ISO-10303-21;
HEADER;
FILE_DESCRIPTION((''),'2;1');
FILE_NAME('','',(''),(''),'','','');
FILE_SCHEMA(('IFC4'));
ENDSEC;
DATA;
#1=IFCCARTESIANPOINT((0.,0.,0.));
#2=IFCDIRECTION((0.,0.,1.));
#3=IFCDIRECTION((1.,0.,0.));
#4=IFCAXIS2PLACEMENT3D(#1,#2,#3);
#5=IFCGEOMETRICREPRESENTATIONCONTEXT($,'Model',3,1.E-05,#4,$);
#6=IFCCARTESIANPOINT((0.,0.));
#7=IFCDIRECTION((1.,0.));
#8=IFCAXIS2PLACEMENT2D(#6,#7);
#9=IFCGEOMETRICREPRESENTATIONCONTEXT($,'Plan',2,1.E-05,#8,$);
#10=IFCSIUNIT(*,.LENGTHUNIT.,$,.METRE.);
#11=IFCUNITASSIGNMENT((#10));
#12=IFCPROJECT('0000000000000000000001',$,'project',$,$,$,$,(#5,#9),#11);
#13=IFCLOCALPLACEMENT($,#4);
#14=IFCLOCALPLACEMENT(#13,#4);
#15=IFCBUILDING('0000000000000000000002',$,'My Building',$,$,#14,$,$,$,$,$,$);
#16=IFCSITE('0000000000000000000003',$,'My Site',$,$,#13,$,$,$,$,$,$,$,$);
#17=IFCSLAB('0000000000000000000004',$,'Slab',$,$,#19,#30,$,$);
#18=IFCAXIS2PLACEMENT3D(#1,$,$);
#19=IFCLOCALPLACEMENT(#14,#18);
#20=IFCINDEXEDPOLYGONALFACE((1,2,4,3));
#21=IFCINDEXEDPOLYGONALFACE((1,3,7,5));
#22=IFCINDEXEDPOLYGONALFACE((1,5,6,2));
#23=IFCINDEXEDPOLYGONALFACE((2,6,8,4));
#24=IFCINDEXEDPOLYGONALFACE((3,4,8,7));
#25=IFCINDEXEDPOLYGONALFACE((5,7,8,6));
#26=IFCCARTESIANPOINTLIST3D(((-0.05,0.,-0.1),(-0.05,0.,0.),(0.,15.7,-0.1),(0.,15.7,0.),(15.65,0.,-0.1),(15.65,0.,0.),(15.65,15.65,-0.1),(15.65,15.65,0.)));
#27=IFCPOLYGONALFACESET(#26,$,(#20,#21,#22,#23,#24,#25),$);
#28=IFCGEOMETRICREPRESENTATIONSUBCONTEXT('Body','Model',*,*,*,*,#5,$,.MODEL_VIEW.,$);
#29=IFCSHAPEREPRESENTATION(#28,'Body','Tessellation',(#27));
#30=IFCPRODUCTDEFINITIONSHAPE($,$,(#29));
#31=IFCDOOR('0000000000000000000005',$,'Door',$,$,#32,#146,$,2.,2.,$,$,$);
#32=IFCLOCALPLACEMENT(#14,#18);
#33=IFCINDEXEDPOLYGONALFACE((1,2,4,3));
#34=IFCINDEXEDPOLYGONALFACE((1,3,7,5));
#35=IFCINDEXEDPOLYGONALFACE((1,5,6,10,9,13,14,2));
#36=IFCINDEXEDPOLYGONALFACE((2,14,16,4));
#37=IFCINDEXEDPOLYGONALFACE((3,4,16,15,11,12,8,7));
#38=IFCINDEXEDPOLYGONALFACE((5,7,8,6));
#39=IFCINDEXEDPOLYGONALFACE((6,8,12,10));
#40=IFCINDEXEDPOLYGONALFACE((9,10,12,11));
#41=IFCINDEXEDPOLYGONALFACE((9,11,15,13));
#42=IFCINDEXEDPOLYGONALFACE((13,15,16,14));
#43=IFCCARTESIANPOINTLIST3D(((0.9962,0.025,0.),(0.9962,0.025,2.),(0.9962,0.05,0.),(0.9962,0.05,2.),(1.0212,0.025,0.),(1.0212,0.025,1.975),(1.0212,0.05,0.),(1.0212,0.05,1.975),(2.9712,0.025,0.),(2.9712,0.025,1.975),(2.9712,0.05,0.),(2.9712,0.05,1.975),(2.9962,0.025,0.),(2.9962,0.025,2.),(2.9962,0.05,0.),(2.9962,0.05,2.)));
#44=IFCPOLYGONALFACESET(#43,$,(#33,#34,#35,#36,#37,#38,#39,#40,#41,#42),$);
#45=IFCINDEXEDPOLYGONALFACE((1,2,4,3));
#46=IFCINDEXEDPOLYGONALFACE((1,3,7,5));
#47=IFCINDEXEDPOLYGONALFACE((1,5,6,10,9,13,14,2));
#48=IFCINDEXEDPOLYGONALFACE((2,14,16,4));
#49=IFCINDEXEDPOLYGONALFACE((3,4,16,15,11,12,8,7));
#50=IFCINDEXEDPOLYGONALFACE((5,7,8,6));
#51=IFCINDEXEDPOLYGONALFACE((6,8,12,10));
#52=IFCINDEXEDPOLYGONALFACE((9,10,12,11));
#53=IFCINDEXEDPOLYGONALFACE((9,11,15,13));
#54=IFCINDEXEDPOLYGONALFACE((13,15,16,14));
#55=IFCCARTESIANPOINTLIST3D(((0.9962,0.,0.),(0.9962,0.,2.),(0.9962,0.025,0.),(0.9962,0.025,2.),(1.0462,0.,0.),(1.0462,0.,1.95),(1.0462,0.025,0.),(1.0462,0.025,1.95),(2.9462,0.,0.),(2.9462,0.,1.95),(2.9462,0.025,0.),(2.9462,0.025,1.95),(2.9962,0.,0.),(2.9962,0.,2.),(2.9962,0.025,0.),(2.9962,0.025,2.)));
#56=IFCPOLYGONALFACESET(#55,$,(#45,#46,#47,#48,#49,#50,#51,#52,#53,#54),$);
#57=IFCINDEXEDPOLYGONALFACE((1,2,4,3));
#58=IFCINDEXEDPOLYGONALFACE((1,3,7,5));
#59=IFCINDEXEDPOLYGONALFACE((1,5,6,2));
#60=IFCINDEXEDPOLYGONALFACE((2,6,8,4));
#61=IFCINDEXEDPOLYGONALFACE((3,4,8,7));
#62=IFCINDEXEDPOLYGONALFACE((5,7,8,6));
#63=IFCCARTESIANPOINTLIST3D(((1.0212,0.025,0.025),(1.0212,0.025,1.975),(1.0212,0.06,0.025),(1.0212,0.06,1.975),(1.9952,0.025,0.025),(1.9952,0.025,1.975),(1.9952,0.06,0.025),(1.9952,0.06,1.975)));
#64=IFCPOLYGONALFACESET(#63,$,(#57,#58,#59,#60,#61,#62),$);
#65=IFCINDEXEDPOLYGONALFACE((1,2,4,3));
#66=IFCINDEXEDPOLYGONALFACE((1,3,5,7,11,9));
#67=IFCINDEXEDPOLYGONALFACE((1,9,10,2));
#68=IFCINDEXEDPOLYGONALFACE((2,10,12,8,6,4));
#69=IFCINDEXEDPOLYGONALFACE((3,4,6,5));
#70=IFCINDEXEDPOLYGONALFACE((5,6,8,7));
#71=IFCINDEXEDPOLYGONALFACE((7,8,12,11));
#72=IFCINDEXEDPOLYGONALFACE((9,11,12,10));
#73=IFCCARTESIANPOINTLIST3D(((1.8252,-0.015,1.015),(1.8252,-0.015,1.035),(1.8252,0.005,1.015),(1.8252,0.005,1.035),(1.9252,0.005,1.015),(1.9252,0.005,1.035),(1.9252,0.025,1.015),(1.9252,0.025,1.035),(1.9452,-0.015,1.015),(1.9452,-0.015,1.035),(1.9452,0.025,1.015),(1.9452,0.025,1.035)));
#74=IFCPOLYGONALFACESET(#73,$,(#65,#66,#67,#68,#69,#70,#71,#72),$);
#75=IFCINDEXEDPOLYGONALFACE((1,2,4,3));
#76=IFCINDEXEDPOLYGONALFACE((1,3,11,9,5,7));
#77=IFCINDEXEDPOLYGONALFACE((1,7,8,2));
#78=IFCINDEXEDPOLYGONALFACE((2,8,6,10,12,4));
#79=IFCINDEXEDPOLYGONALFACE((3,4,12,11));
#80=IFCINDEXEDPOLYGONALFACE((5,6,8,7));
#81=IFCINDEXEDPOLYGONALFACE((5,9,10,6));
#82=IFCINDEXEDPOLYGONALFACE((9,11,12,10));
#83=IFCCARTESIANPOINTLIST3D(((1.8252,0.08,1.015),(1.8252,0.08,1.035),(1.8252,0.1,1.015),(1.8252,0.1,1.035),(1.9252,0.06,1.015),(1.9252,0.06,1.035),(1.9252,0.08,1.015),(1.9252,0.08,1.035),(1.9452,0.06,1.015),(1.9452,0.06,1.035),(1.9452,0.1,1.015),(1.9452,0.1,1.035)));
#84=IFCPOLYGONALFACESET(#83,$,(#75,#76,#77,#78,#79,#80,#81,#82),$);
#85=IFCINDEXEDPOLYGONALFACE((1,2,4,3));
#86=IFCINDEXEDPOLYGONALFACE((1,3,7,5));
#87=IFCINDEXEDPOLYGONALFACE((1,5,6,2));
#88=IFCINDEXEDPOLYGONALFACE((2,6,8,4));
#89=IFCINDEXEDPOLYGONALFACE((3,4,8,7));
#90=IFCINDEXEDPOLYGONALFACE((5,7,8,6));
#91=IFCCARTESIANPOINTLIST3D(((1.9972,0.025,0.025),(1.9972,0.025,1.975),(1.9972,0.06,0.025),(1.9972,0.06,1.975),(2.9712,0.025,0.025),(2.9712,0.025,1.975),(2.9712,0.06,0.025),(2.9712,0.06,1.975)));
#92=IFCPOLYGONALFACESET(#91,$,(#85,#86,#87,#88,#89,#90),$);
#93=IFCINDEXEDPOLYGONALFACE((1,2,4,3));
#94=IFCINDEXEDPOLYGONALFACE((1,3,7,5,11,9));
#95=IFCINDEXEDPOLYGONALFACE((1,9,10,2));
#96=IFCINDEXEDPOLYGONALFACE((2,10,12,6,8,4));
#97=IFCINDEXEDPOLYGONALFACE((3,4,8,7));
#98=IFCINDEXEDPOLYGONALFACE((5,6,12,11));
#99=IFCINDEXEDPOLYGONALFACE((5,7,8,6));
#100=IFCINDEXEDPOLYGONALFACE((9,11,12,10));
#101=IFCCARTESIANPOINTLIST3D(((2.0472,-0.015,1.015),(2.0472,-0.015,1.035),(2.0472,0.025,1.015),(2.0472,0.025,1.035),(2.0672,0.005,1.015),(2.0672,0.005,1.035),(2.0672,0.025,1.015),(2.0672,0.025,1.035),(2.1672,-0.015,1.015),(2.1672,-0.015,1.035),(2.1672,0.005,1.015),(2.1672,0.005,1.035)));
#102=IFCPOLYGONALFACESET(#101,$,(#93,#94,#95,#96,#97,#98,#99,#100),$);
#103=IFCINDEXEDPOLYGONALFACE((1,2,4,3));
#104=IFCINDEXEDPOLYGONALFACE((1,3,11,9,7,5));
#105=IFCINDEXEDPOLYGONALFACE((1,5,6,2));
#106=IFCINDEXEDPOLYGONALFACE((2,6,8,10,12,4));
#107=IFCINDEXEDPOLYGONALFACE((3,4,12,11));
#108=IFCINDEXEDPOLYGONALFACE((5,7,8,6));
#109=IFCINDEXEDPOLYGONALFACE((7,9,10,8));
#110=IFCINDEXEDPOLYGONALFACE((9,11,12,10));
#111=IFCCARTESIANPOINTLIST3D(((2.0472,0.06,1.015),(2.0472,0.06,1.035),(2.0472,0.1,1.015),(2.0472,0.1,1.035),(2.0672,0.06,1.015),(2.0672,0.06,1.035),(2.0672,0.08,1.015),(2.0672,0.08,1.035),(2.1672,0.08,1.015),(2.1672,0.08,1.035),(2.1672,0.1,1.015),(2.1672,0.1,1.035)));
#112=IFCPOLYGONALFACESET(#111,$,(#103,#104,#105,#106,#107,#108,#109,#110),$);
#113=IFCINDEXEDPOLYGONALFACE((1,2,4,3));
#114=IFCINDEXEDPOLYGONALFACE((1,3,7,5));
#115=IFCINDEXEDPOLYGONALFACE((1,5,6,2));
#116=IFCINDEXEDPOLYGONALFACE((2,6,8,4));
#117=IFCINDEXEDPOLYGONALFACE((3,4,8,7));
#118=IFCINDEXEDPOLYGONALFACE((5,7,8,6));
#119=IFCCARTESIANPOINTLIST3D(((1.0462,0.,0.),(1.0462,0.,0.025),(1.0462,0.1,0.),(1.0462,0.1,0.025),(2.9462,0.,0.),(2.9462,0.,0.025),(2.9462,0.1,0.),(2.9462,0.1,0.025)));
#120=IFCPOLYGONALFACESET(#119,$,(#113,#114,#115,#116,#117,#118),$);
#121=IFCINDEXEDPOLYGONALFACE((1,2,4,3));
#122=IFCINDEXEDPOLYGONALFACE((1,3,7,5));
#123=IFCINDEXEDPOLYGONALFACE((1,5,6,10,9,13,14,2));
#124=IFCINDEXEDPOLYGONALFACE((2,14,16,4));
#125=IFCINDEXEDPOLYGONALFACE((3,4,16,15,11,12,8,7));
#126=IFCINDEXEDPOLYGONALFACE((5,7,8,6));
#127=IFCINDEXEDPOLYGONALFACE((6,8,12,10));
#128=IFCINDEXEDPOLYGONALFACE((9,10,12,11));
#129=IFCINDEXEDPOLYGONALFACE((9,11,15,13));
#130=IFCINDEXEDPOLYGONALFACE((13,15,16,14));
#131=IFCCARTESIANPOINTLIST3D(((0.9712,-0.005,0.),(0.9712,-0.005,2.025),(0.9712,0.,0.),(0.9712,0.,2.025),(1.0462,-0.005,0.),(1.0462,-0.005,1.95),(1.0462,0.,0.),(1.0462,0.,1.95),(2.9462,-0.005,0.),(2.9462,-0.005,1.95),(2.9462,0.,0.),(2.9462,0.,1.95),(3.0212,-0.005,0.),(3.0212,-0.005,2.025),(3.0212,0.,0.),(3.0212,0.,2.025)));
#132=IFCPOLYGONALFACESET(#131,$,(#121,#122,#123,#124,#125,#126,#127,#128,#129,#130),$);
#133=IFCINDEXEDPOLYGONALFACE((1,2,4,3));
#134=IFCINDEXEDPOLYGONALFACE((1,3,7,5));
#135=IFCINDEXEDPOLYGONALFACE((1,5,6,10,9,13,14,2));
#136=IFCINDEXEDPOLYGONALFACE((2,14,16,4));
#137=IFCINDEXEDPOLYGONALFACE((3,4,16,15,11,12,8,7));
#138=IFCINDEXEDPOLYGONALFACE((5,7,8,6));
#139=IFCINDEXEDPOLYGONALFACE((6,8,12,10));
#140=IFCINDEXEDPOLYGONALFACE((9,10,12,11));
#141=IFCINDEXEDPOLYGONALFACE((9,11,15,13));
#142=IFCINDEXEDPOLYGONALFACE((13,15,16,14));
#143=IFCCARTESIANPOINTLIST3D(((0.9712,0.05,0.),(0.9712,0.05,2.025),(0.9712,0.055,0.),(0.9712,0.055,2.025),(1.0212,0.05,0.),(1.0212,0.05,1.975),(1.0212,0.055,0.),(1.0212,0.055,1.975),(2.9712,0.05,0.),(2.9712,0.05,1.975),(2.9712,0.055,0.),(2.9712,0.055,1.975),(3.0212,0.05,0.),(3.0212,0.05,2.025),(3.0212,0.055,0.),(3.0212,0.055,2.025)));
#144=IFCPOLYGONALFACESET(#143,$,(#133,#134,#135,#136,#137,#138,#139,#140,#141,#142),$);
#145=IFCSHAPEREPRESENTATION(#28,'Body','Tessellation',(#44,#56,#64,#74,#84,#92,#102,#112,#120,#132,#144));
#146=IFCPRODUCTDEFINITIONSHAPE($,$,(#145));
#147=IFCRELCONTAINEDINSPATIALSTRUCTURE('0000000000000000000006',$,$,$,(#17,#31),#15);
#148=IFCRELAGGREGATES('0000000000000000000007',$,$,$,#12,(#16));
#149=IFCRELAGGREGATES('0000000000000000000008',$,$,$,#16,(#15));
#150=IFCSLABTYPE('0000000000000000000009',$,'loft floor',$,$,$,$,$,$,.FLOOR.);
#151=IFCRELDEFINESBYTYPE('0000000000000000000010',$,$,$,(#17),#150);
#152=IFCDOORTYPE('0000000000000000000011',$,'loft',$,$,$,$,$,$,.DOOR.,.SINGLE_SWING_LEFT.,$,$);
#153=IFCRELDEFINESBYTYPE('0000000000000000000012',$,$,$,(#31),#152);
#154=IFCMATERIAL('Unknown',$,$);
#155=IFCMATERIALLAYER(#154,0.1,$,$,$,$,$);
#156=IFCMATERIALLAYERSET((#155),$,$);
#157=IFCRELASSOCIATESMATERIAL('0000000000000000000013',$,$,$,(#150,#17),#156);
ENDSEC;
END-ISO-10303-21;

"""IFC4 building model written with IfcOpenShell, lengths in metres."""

from ifc_helpers import new_model, entity, si_unit, frame, origin_with_axes, origin_2d_with_axis, place, context, subcontext, project, spatial, line, indexed_curve, outline, extrude, shape, source, transform, mapped, material, layer, layer_set, layer_usage, type_object, type_shapes, element, save


model = new_model("IFC4")

# Units and contexts
model_context = context("Model", 3, precision=1e-05, world=origin_with_axes())
plan_context = context("Plan", 2, precision=1e-05, world=origin_2d_with_axis())
body_context_1 = subcontext(model_context, "Body", "Model", "MODEL_VIEW")
body_context_2 = subcontext(plan_context, "Body", "Plan", "PLAN_VIEW")
ifc_project = project(units=[si_unit("LENGTHUNIT", "METRE")], contexts=[model_context, plan_context])

# Site, building
site_placement = place(None, origin_with_axes())
site = spatial("IfcSite", under=ifc_project, at=site_placement, Name="My Site")
building_placement = place(site_placement, origin_with_axes())
building = spatial("IfcBuilding", under=site, at=building_placement, Name="My Building")

# Slab
ifc_material = material(Name="Unknown")
ifc_layer = layer(ifc_material, 0.1)
ifc_layer_set = layer_set([ifc_layer])
ifc_layer_usage = layer_usage(ifc_layer_set, "AXIS3", "POSITIVE", -0.1)
slab_type = type_object("IfcSlabType", Name="loft floor", PredefinedType="FLOOR", material=ifc_layer_set)
slab_placement = place(building_placement, frame((0.0, 15.7, 0.0), z_axis=(0.0, 0.0, 1.0), x_axis=(1.0, 0.0, 0.0)))
element("IfcSlab", 1, at=slab_placement, inside=building, type_object=slab_type, material=ifc_layer_usage, Name="Slab", context=body_context_1, shape_type="SweptSolid", body=[
    extrude(outline(indexed_curve([(0.0, 0.0), (15.65, -0.05), (15.65, -15.7), (-0.05, -15.7), (0.0, 0.0)])), frame((0.0, 0.0, -0.1), z_axis=(0.0, 0.0, 1.0), x_axis=(1.0, 0.0, 0.0)), (0.0, 0.0, 1.0), 0.1),
])

# Door
door_type = type_object("IfcDoorType", Name="loft", OperationType="SINGLE_SWING_LEFT", PredefinedType="DOOR")
shared_shape_1 = source(origin_with_axes(), body_context_1, "Body", "SweptSolid", [
    extrude(outline(indexed_curve([(0.0, 0.0), (0.0, 2.0), (2.0, 2.0), (2.0, 0.0), (1.975, 0.0), (1.975, 1.975), (0.025, 1.975), (0.025, 0.0)], segments=[line(1, 2, 3, 4, 5, 6, 7, 8, 1)])), frame((0.0, 0.025, 0.0), z_axis=(0.0, -1.0, 0.0), x_axis=(1.0, 0.0, 0.0)), (0.0, 0.0, -1.0), 0.025),
    extrude(outline(indexed_curve([(0.0, 0.0), (0.0, 2.0), (2.0, 2.0), (2.0, 0.0), (1.95, 0.0), (1.95, 1.95), (0.05, 1.95), (0.05, 0.0)], segments=[line(1, 2, 3, 4, 5, 6, 7, 8, 1)])), frame((0.0, 0.0, 0.0), z_axis=(0.0, -1.0, 0.0), x_axis=(1.0, 0.0, 0.0)), (0.0, 0.0, -1.0), 0.025),
    extrude(outline(indexed_curve([(0.0, 0.0), (0.974, 0.0), (0.974, 0.035), (0.0, 0.035)], segments=[line(1, 2, 3, 4, 1)])), frame((0.025, 0.025, 0.025), z_axis=(0.0, 0.0, 1.0), x_axis=(1.0, 0.0, 0.0)), (0.0, 0.0, 1.0), 1.95),
    extrude(outline(indexed_curve([(0.0, 0.0), (0.0, -0.04), (-0.12, -0.04), (-0.12, -0.02), (-0.02, -0.02), (-0.02, 0.0)], segments=[line(1, 2, 3, 4, 5, 6, 1)])), frame((0.949, 0.025, 1.015), z_axis=(0.0, 0.0, 1.0), x_axis=(1.0, 0.0, 0.0)), (0.0, 0.0, 1.0), 0.02),
    extrude(outline(indexed_curve([(0.0, 0.0), (0.0, 0.04), (-0.12, 0.04), (-0.12, 0.02), (-0.02, 0.02), (-0.02, 0.0)], segments=[line(1, 2, 3, 4, 5, 6, 1)])), frame((0.949, 0.06, 1.015), z_axis=(0.0, 0.0, 1.0), x_axis=(1.0, 0.0, 0.0)), (0.0, 0.0, 1.0), 0.02),
    extrude(outline(indexed_curve([(0.0, 0.0), (-0.974, 0.0), (-0.974, 0.035), (0.0, 0.035)], segments=[line(1, 2, 3, 4, 1)])), frame((1.975, 0.025, 0.025), z_axis=(0.0, 0.0, 1.0), x_axis=(1.0, 0.0, 0.0)), (0.0, 0.0, 1.0), 1.95),
    extrude(outline(indexed_curve([(0.0, 0.0), (0.0, -0.04), (0.12, -0.04), (0.12, -0.02), (0.02, -0.02), (0.02, 0.0)], segments=[line(1, 2, 3, 4, 5, 6, 1)])), frame((1.051, 0.025, 1.015), z_axis=(0.0, 0.0, 1.0), x_axis=(1.0, 0.0, 0.0)), (0.0, 0.0, 1.0), 0.02),
    extrude(outline(indexed_curve([(0.0, 0.0), (0.0, 0.04), (0.12, 0.04), (0.12, 0.02), (0.02, 0.02), (0.02, 0.0)], segments=[line(1, 2, 3, 4, 5, 6, 1)])), frame((1.051, 0.06, 1.015), z_axis=(0.0, 0.0, 1.0), x_axis=(1.0, 0.0, 0.0)), (0.0, 0.0, 1.0), 0.02),
    extrude(outline(indexed_curve([(0.0, 0.0), (1.9, 0.0), (1.9, 0.1), (0.0, 0.1)], segments=[line(1, 2, 3, 4, 1)])), frame((0.05, 0.0, 0.0), z_axis=(0.0, 0.0, 1.0), x_axis=(1.0, 0.0, 0.0)), (0.0, 0.0, 1.0), 0.025),
    extrude(outline(indexed_curve([(0.0, 0.0), (0.0, 2.025), (2.05, 2.025), (2.05, 0.0), (1.975, 0.0), (1.975, 1.95), (0.075, 1.95), (0.075, 0.0)], segments=[line(1, 2, 3, 4, 5, 6, 7, 8, 1)])), frame((-0.025, -0.005, 0.0), z_axis=(0.0, -1.0, 0.0), x_axis=(1.0, 0.0, 0.0)), (0.0, 0.0, -1.0), 0.005),
    extrude(outline(indexed_curve([(0.0, 0.0), (0.0, 2.025), (2.05, 2.025), (2.05, 0.0), (2.0, 0.0), (2.0, 1.975), (0.05, 1.975), (0.05, 0.0)], segments=[line(1, 2, 3, 4, 5, 6, 7, 8, 1)])), frame((-0.025, 0.05, 0.0), z_axis=(0.0, -1.0, 0.0), x_axis=(1.0, 0.0, 0.0)), (0.0, 0.0, -1.0), 0.005),
])
shared_shape_2 = source(origin_with_axes(), body_context_2, "Body", "Curve2D", [
    entity("IfcIndexedPolyCurve", entity("IfcCartesianPointList2D", [[0.0, 0.0], [0.0, 0.05], [0.025, 0.05], [0.025, 0.025], [0.05, 0.025], [0.05, 0.0]]), [entity("IfcLineIndex", [1, 2, 3, 4, 5, 6, 1])]),
    entity("IfcIndexedPolyCurve", entity("IfcCartesianPointList2D", [[2.0, 0.0], [2.0, 0.05], [1.975, 0.05], [1.975, 0.025], [1.95, 0.025], [1.95, 0.0]]), [entity("IfcLineIndex", [1, 2, 3, 4, 5, 6, 1])]),
    entity("IfcTrimmedCurve", entity("IfcEllipse", entity("IfcAxis2Placement2D", entity("IfcCartesianPoint", [0.06, 0.05]), entity("IfcDirection", [1.0, 0.0])), 0.94, 0.975), [entity("IfcCartesianPoint", [1.0, 0.05])], [entity("IfcCartesianPoint", [0.06, 1.025])], True, "CARTESIAN"),
    entity("IfcIndexedPolyCurve", entity("IfcCartesianPointList2D", [[0.025, 0.05], [0.06, 0.05], [0.06, 1.025], [0.025, 1.025]]), [entity("IfcLineIndex", [1, 2, 3, 4, 1])]),
    entity("IfcTrimmedCurve", entity("IfcEllipse", entity("IfcAxis2Placement2D", entity("IfcCartesianPoint", [1.94, 0.05]), entity("IfcDirection", [1.0, 0.0])), 0.94, 0.975), [entity("IfcCartesianPoint", [1.94, 1.025])], [entity("IfcCartesianPoint", [1.0, 0.05])], True, "CARTESIAN"),
    entity("IfcIndexedPolyCurve", entity("IfcCartesianPointList2D", [[1.975, 0.05], [1.94, 0.05], [1.94, 1.025], [1.975, 1.025]]), [entity("IfcLineIndex", [1, 2, 3, 4, 1])]),
])
type_shapes(door_type, [shared_shape_1, shared_shape_2])
door_placement = place(building_placement, frame((0.9962, 0.0, 0.0), z_axis=(0.0, 0.0, 1.0), x_axis=(1.0, 0.0, 0.0)))
element("IfcDoor", 2, at=door_placement, inside=building, type_object=door_type, Name="Door", OverallHeight=2.0, OverallWidth=2.0, shapes=[
    shape(body_context_1, "Body", "MappedRepresentation", [mapped(shared_shape_1, transform((0.0, 0.0, 0.0), x_axis=(1.0, 0.0, 0.0), y_axis=(0.0, 1.0, 0.0), z_axis=(0.0, 0.0, 1.0), scale=1.0))]),
    shape(body_context_2, "Body", "MappedRepresentation", [mapped(shared_shape_2, transform((0.0, 0.0, 0.0), x_axis=(1.0, 0.0, 0.0), y_axis=(0.0, 1.0, 0.0), z_axis=(0.0, 0.0, 1.0), scale=1.0))]),
])

save(model, "model.ifc")
